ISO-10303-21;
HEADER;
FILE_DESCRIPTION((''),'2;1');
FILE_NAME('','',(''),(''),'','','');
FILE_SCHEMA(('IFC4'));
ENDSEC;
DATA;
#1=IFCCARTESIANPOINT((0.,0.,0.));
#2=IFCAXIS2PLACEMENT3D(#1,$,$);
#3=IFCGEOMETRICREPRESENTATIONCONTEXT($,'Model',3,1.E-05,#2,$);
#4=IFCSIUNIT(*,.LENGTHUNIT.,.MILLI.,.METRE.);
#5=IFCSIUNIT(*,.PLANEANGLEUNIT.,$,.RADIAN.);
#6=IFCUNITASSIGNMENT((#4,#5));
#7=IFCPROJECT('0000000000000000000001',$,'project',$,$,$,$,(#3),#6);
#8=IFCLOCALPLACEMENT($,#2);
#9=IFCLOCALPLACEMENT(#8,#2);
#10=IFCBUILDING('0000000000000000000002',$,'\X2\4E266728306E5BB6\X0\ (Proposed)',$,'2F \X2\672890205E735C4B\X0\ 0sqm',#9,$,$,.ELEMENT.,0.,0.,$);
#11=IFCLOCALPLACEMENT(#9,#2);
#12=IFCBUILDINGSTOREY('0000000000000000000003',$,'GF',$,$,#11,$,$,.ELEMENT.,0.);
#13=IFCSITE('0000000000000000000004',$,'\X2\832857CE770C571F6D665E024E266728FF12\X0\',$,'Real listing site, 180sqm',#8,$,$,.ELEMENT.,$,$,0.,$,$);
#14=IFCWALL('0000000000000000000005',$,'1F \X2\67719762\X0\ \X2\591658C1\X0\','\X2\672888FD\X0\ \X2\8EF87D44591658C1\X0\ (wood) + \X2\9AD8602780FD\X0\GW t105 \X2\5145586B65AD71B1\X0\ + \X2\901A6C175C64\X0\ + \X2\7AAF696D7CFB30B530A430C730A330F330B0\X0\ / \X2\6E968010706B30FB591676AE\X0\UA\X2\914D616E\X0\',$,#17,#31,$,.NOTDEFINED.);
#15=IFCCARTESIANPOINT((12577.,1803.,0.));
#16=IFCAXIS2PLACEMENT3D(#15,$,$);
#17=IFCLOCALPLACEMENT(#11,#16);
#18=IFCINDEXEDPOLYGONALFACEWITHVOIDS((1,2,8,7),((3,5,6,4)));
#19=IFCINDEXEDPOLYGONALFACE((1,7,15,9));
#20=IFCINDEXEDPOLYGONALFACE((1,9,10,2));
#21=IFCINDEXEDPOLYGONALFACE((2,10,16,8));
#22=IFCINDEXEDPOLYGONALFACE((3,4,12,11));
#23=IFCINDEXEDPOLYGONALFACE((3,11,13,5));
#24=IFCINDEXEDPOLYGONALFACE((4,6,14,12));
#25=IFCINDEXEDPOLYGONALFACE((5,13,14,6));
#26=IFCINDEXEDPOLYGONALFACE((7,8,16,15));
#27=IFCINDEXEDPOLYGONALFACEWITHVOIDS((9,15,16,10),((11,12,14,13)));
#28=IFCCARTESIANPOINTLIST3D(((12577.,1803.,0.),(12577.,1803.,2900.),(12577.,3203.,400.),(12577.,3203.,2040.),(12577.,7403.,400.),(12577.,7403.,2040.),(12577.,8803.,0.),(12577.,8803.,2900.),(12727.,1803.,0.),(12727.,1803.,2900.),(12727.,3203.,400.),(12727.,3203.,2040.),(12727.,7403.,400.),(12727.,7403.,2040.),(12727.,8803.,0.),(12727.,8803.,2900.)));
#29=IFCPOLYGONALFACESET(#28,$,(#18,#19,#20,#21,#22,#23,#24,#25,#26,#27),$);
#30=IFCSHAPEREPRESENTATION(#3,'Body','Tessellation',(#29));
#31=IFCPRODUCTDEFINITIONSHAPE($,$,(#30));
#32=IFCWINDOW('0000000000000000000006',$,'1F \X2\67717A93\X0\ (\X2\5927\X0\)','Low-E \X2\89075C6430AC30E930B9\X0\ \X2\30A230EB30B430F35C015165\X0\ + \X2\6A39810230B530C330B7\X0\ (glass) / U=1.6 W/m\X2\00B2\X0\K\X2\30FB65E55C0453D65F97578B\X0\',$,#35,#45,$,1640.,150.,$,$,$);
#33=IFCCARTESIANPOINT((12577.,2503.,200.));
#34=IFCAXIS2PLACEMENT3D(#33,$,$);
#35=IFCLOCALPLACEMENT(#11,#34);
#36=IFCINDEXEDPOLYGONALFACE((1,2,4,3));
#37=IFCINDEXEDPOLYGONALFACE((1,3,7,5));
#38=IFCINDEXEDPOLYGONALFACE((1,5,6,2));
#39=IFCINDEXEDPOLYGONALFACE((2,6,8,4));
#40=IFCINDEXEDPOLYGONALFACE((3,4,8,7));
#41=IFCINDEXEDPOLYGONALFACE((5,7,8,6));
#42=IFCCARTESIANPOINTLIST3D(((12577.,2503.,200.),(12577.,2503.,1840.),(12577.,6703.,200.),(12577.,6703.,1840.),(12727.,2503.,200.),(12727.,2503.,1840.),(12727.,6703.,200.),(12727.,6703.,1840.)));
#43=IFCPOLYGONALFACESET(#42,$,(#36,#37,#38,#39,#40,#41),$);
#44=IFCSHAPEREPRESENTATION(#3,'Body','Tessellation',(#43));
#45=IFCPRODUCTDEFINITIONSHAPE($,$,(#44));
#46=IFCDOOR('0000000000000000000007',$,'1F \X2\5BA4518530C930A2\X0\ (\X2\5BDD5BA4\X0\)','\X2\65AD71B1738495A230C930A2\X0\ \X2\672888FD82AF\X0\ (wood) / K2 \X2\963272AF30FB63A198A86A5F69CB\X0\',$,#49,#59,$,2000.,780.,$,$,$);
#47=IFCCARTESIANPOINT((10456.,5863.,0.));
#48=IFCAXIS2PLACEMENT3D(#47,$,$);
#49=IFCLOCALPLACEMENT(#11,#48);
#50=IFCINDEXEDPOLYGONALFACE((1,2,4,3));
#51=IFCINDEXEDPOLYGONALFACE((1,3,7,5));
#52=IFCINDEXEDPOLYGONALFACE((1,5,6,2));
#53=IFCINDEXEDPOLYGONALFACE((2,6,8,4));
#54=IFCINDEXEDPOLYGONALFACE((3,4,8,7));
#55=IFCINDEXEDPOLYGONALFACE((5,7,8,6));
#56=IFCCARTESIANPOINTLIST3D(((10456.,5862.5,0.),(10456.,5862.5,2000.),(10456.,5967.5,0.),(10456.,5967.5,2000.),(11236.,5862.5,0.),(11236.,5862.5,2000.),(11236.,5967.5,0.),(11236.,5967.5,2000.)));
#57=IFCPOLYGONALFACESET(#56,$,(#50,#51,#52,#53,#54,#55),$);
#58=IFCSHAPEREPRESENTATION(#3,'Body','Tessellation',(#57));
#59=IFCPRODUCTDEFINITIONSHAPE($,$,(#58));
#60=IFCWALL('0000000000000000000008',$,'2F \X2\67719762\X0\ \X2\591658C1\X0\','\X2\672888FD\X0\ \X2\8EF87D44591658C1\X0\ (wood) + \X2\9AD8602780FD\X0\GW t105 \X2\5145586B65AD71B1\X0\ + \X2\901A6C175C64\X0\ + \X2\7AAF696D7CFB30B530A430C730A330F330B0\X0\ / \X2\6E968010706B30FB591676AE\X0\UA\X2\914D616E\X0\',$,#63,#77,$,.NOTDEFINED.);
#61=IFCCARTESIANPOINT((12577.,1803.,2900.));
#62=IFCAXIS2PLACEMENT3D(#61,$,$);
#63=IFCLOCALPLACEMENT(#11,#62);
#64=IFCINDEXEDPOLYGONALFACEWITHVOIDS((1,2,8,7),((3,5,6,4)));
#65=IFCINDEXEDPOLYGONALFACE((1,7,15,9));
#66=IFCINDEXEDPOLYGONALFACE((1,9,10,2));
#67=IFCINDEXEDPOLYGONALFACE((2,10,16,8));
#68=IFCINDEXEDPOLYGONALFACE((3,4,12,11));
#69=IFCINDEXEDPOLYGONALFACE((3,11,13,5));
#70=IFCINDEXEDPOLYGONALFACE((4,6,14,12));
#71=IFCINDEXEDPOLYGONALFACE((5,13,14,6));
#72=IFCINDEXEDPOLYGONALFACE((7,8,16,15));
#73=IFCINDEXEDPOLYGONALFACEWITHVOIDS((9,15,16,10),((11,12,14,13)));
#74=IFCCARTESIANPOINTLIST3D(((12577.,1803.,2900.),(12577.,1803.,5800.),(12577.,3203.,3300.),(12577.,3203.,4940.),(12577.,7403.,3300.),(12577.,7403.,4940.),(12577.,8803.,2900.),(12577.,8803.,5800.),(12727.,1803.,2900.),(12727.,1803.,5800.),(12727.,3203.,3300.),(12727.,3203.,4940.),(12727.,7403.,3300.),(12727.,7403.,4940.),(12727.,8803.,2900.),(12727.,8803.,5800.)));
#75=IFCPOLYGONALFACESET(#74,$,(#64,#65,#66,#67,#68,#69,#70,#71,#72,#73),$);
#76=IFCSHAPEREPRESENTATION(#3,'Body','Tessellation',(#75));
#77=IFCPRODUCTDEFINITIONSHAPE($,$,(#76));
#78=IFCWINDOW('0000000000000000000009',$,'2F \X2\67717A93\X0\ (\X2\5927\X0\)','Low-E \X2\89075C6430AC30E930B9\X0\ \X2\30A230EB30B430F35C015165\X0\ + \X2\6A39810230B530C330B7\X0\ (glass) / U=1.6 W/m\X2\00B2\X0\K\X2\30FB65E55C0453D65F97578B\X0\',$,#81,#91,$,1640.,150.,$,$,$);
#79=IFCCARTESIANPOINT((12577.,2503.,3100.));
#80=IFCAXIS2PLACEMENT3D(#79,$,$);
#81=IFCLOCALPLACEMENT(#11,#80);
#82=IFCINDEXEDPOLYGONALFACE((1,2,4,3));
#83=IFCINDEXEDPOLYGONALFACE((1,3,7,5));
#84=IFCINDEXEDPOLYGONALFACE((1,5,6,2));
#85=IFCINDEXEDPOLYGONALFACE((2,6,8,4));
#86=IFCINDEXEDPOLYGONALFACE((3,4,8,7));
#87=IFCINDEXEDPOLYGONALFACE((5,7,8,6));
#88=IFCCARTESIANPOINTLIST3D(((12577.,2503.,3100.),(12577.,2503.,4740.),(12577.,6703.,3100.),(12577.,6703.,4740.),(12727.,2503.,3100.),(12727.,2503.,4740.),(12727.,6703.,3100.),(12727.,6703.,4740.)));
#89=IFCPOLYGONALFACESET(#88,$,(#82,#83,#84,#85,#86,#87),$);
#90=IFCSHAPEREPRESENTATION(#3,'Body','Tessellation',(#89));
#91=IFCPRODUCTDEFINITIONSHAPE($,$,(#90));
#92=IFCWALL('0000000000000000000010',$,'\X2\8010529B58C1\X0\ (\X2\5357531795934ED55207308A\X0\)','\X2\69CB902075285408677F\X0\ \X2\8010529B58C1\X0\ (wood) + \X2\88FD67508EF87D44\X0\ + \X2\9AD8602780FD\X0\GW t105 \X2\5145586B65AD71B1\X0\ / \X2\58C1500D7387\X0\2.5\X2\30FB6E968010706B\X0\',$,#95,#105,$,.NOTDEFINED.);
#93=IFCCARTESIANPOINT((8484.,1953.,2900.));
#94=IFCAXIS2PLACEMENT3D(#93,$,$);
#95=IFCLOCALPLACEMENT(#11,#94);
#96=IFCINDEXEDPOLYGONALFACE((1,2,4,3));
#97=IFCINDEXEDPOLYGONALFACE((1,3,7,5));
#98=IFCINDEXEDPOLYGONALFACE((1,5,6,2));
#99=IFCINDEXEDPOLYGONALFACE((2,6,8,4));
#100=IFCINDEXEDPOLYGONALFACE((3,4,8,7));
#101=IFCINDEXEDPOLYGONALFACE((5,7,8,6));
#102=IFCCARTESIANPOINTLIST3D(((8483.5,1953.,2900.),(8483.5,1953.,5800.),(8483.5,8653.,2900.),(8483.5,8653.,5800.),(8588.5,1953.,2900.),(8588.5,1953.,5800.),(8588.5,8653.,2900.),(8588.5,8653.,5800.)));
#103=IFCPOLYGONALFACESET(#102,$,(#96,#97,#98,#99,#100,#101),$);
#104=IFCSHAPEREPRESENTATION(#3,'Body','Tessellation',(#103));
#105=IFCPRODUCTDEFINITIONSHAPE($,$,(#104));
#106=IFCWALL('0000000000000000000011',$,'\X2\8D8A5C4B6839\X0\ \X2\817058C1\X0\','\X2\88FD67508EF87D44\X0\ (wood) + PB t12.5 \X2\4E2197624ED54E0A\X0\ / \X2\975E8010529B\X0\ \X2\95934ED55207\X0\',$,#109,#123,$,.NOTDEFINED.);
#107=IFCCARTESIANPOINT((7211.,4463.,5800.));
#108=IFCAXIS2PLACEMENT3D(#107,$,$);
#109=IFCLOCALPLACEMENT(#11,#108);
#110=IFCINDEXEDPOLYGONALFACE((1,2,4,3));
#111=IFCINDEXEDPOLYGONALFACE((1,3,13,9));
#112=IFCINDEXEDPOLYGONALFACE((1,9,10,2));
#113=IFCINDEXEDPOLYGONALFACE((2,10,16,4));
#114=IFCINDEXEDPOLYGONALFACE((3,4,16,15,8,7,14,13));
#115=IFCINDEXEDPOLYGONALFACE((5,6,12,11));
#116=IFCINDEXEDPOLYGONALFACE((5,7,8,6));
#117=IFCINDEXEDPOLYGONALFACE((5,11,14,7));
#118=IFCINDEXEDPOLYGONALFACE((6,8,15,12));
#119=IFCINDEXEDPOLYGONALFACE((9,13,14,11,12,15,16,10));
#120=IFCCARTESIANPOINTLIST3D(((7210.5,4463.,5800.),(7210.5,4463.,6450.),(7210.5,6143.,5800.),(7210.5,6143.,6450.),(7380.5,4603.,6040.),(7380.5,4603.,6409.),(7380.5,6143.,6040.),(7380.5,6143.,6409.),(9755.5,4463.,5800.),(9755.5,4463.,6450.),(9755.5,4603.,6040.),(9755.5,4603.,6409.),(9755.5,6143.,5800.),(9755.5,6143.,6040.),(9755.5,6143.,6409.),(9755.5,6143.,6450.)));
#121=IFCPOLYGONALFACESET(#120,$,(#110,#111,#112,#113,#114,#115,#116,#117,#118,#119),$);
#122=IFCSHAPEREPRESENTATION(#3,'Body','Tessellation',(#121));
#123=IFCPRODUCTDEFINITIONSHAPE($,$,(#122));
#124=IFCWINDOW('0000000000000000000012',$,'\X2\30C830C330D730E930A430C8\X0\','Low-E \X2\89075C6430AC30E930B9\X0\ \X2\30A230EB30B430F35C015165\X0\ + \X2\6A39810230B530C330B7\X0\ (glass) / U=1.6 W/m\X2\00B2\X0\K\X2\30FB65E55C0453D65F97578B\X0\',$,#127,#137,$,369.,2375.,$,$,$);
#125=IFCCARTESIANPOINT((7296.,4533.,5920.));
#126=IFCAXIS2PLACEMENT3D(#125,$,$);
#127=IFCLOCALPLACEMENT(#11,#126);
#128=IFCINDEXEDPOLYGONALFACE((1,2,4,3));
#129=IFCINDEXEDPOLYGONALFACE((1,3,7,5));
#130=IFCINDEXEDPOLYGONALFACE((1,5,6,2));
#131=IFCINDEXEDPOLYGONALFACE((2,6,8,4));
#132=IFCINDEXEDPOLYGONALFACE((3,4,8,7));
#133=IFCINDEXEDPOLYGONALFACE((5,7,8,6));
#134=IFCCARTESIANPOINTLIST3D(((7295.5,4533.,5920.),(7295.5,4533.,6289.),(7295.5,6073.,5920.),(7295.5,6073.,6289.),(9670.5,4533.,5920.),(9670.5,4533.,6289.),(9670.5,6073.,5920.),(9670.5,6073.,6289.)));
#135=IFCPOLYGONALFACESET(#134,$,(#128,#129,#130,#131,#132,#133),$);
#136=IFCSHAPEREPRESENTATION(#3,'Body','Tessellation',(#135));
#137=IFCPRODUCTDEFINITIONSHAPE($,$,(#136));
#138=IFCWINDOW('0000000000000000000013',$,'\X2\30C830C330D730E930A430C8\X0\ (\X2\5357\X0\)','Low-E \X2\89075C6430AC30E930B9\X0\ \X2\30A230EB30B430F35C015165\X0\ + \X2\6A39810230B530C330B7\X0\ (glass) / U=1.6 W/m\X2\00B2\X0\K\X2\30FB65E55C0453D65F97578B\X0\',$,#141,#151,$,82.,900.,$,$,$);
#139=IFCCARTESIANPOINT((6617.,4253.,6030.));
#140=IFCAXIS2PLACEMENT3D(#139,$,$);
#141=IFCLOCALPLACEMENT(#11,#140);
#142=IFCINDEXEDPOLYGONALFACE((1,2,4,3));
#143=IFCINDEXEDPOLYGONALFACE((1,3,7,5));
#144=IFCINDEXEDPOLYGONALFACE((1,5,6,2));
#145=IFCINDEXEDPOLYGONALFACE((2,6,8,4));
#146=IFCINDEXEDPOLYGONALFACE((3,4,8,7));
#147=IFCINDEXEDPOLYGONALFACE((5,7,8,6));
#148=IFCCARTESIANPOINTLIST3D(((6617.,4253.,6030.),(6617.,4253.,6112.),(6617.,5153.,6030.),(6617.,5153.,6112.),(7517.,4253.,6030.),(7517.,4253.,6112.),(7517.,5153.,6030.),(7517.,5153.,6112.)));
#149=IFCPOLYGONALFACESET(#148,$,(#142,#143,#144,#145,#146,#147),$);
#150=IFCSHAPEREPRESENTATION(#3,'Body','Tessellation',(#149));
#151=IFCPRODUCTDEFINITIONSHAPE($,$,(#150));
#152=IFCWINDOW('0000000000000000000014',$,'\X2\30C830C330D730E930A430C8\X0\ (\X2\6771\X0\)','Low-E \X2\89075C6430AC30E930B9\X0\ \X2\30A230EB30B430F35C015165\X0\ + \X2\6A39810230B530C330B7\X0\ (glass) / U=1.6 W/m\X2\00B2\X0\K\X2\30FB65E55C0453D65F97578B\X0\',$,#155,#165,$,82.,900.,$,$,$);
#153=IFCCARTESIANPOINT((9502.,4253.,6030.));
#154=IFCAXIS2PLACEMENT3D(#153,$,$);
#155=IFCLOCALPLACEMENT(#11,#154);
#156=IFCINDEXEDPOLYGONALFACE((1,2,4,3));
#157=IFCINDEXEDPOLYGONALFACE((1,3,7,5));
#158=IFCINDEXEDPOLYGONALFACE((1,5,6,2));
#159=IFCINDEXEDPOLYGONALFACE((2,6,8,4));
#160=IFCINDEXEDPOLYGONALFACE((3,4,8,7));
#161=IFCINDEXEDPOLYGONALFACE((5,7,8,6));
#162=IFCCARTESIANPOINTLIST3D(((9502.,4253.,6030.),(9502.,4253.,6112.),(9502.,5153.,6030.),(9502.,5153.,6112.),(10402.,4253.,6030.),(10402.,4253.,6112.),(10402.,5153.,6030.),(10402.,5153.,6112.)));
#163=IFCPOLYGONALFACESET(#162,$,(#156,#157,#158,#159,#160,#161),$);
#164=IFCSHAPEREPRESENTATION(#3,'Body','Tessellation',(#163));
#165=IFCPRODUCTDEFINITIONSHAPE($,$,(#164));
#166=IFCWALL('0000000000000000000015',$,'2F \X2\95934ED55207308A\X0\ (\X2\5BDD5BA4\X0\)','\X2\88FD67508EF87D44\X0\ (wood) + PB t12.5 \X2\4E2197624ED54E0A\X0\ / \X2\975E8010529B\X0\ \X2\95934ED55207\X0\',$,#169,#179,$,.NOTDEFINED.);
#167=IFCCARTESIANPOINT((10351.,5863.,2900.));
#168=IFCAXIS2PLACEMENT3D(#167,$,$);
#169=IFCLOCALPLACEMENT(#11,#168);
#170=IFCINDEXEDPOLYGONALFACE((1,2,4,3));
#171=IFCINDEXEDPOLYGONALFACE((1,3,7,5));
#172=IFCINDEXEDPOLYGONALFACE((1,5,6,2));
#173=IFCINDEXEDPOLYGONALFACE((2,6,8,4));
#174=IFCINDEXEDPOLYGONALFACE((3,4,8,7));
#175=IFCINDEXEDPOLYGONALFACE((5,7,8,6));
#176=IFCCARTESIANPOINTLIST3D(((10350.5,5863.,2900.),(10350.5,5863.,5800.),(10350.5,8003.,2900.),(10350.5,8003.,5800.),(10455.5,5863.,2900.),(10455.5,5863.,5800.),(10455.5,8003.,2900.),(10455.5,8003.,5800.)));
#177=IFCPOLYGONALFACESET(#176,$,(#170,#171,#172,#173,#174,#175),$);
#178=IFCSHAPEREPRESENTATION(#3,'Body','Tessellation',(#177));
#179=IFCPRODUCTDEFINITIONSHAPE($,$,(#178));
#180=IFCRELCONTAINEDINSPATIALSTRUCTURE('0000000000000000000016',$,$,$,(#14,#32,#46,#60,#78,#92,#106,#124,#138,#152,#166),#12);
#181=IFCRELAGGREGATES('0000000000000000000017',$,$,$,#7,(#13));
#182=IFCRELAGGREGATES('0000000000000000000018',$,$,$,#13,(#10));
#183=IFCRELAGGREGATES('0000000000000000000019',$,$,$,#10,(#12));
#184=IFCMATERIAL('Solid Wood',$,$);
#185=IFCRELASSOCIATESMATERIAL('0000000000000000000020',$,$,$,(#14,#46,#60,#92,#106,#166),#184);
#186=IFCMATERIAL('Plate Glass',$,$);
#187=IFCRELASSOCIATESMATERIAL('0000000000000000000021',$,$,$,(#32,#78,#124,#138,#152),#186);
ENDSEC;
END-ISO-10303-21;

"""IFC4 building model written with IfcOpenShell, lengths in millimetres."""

from ifc_helpers import new_model, si_unit, frame, frame_2d, origin, place, context, project, spatial, rectangle, extrude, material, element, fill, save


model = new_model("IFC4")

# Units and contexts
model_context = context("Model", 3, precision=1e-05, world=origin())
ifc_project = project(units=[si_unit("LENGTHUNIT", "METRE", prefix="MILLI"), si_unit("PLANEANGLEUNIT", "RADIAN")], contexts=[model_context])

# Site, building, storey
site_placement = place(None, origin())
site = spatial("IfcSite", under=ifc_project, at=site_placement, Name="茨城県土浦市並木２", ObjectType="Real listing site, 180sqm", CompositionType="ELEMENT", RefElevation=0.0)
building_placement = place(site_placement, origin())
building = spatial("IfcBuilding", under=site, at=building_placement, Name="並木の家 (Proposed)", ObjectType="2F 木造平屋 0sqm", CompositionType="ELEMENT", ElevationOfRefHeight=0.0, ElevationOfTerrain=0.0)
storey_placement = place(building_placement, origin())
storey = spatial("IfcBuildingStorey", under=building, at=storey_placement, Name="GF", CompositionType="ELEMENT", Elevation=0.0)

# Wall, opening, window
ifc_material_1 = material(Name="Solid Wood")
wall_1_placement = place(storey_placement, frame((12577.0, 1803.0, 0.0)))
wall_1 = element("IfcWall", 1, at=wall_1_placement, inside=storey, material=ifc_material_1, Name="1F 東面 外壁", Description="木製 軸組外壁 (wood) + 高性能GW t105 充填断熱 + 通気層 + 窯業系サイディング / 準耐火・外皮UA配慮", PredefinedType="NOTDEFINED", context=model_context, shape_type="SweptSolid", body=[
    extrude(rectangle(XDim=150.0, YDim=7000.0, at=frame_2d((75.0, 3500.0))), frame((12577.0, 1803.0, 0.0)), (0.0, 0.0, 1.0), 2900.0),
])
opening_1_placement = place(storey_placement, frame((12577.0, 2503.0, 200.0)))
opening_1 = element("IfcOpeningElement", 2, at=opening_1_placement, cuts=wall_1, PredefinedType="NOTDEFINED", context=model_context, shape_type="SweptSolid", body=[
    extrude(rectangle(XDim=150.0, YDim=4200.0, at=frame_2d((75.0, 2100.0))), frame((12577.0, 2503.0, 200.0)), (0.0, 0.0, 1.0), 1640.0),
])
ifc_material_2 = material(Name="Plate Glass")
window_1_placement = place(storey_placement, frame((12577.0, 2503.0, 200.0)))
window_1 = element("IfcWindow", 3, at=window_1_placement, inside=storey, material=ifc_material_2, Name="1F 東窓 (大)", Description="Low-E 複層ガラス アルゴン封入 + 樹脂サッシ (glass) / U=1.6 W/m²K・日射取得型", OverallHeight=1640.0, OverallWidth=150.0, context=model_context, shape_type="SweptSolid", body=[
    extrude(rectangle(XDim=150.0, YDim=4200.0, at=frame_2d((75.0, 2100.0))), frame((12577.0, 2503.0, 200.0)), (0.0, 0.0, 1.0), 1640.0),
])
fill(opening_1, window_1)

# Door
door_1_placement = place(storey_placement, frame((10456.0, 5863.0, 0.0)))
element("IfcDoor", 4, at=door_1_placement, inside=storey, material=ifc_material_1, Name="1F 室内ドア (寝室)", Description="断熱玄関ドア 木製芯 (wood) / K2 防犯・採風機構", OverallHeight=2000.0, OverallWidth=780.0, context=model_context, shape_type="SweptSolid", body=[
    extrude(rectangle(XDim=780.0, YDim=105.0, at=frame_2d((390.0, 52.0))), frame((10456.0, 5863.0, 0.0)), (0.0, 0.0, 1.0), 2000.0),
])

# Wall, opening, window
wall_2_placement = place(storey_placement, frame((12577.0, 1803.0, 2900.0)))
wall_2 = element("IfcWall", 5, at=wall_2_placement, inside=storey, material=ifc_material_1, Name="2F 東面 外壁", Description="木製 軸組外壁 (wood) + 高性能GW t105 充填断熱 + 通気層 + 窯業系サイディング / 準耐火・外皮UA配慮", PredefinedType="NOTDEFINED", context=model_context, shape_type="SweptSolid", body=[
    extrude(rectangle(XDim=150.0, YDim=7000.0, at=frame_2d((75.0, 3500.0))), frame((12577.0, 1803.0, 2900.0)), (0.0, 0.0, 1.0), 2900.0),
])
opening_2_placement = place(storey_placement, frame((12577.0, 2503.0, 3100.0)))
opening_2 = element("IfcOpeningElement", 6, at=opening_2_placement, cuts=wall_2, PredefinedType="NOTDEFINED", context=model_context, shape_type="SweptSolid", body=[
    extrude(rectangle(XDim=150.0, YDim=4200.0, at=frame_2d((75.0, 2100.0))), frame((12577.0, 2503.0, 3100.0)), (0.0, 0.0, 1.0), 1640.0),
])
window_2_placement = place(storey_placement, frame((12577.0, 2503.0, 3100.0)))
window_2 = element("IfcWindow", 7, at=window_2_placement, inside=storey, material=ifc_material_2, Name="2F 東窓 (大)", Description="Low-E 複層ガラス アルゴン封入 + 樹脂サッシ (glass) / U=1.6 W/m²K・日射取得型", OverallHeight=1640.0, OverallWidth=150.0, context=model_context, shape_type="SweptSolid", body=[
    extrude(rectangle(XDim=150.0, YDim=4200.0, at=frame_2d((75.0, 2100.0))), frame((12577.0, 2503.0, 3100.0)), (0.0, 0.0, 1.0), 1640.0),
])
fill(opening_2, window_2)

# Wall
wall_3_placement = place(storey_placement, frame((8484.0, 1953.0, 2900.0)))
element("IfcWall", 8, at=wall_3_placement, inside=storey, material=ifc_material_1, Name="耐力壁 (南北間仕切り)", Description="構造用合板 耐力壁 (wood) + 製材軸組 + 高性能GW t105 充填断熱 / 壁倍率2.5・準耐火", PredefinedType="NOTDEFINED", context=model_context, shape_type="SweptSolid", body=[
    extrude(rectangle(XDim=105.0, YDim=6700.0, at=frame_2d((52.0, 3350.0))), frame((8484.0, 1953.0, 2900.0)), (0.0, 0.0, 1.0), 2900.0),
])

# Wall, openings, windows
wall_4_placement = place(storey_placement, frame((7211.0, 4463.0, 5800.0)))
wall_4 = element("IfcWall", 9, at=wall_4_placement, inside=storey, material=ifc_material_1, Name="越屋根 腰壁", Description="製材軸組 (wood) + PB t12.5 両面仕上 / 非耐力 間仕切", PredefinedType="NOTDEFINED", context=model_context, shape_type="SweptSolid", body=[
    extrude(rectangle(XDim=2545.0, YDim=1680.0, at=frame_2d((1272.0, 840.0))), frame((7211.0, 4463.0, 5800.0)), (0.0, 0.0, 1.0), 650.0),
])
opening_3_placement = place(storey_placement, frame((7296.0, 4533.0, 5920.0)))
opening_3 = element("IfcOpeningElement", 10, at=opening_3_placement, cuts=wall_4, PredefinedType="NOTDEFINED", context=model_context, shape_type="SweptSolid", body=[
    extrude(rectangle(XDim=2375.0, YDim=1540.0, at=frame_2d((1187.0, 770.0))), frame((7296.0, 4533.0, 5920.0)), (0.0, 0.0, 1.0), 369.0),
])
opening_4_placement = place(storey_placement, frame((6617.0, 4253.0, 6030.0)))
opening_4 = element("IfcOpeningElement", 11, at=opening_4_placement, cuts=wall_4, PredefinedType="NOTDEFINED", context=model_context, shape_type="SweptSolid", body=[
    extrude(rectangle(XDim=900.0, YDim=900.0, at=frame_2d((450.0, 450.0))), frame((6617.0, 4253.0, 6030.0)), (0.0, 0.0, 1.0), 82.0),
])
opening_5_placement = place(storey_placement, frame((9502.0, 4253.0, 6030.0)))
opening_5 = element("IfcOpeningElement", 12, at=opening_5_placement, cuts=wall_4, PredefinedType="NOTDEFINED", context=model_context, shape_type="SweptSolid", body=[
    extrude(rectangle(XDim=900.0, YDim=900.0, at=frame_2d((450.0, 450.0))), frame((9502.0, 4253.0, 6030.0)), (0.0, 0.0, 1.0), 82.0),
])
window_3_placement = place(storey_placement, frame((7296.0, 4533.0, 5920.0)))
window_3 = element("IfcWindow", 13, at=window_3_placement, inside=storey, material=ifc_material_2, Name="トップライト", Description="Low-E 複層ガラス アルゴン封入 + 樹脂サッシ (glass) / U=1.6 W/m²K・日射取得型", OverallHeight=369.0, OverallWidth=2375.0, context=model_context, shape_type="SweptSolid", body=[
    extrude(rectangle(XDim=2375.0, YDim=1540.0, at=frame_2d((1187.0, 770.0))), frame((7296.0, 4533.0, 5920.0)), (0.0, 0.0, 1.0), 369.0),
])
fill(opening_3, window_3)
window_4_placement = place(storey_placement, frame((6617.0, 4253.0, 6030.0)))
window_4 = element("IfcWindow", 14, at=window_4_placement, inside=storey, material=ifc_material_2, Name="トップライト (南)", Description="Low-E 複層ガラス アルゴン封入 + 樹脂サッシ (glass) / U=1.6 W/m²K・日射取得型", OverallHeight=82.0, OverallWidth=900.0, context=model_context, shape_type="SweptSolid", body=[
    extrude(rectangle(XDim=900.0, YDim=900.0, at=frame_2d((450.0, 450.0))), frame((6617.0, 4253.0, 6030.0)), (0.0, 0.0, 1.0), 82.0),
])
fill(opening_4, window_4)
window_5_placement = place(storey_placement, frame((9502.0, 4253.0, 6030.0)))
window_5 = element("IfcWindow", 15, at=window_5_placement, inside=storey, material=ifc_material_2, Name="トップライト (東)", Description="Low-E 複層ガラス アルゴン封入 + 樹脂サッシ (glass) / U=1.6 W/m²K・日射取得型", OverallHeight=82.0, OverallWidth=900.0, context=model_context, shape_type="SweptSolid", body=[
    extrude(rectangle(XDim=900.0, YDim=900.0, at=frame_2d((450.0, 450.0))), frame((9502.0, 4253.0, 6030.0)), (0.0, 0.0, 1.0), 82.0),
])
fill(opening_5, window_5)

# Wall
wall_5_placement = place(storey_placement, frame((10351.0, 5863.0, 2900.0)))
element("IfcWall", 16, at=wall_5_placement, inside=storey, material=ifc_material_1, Name="2F 間仕切り (寝室)", Description="製材軸組 (wood) + PB t12.5 両面仕上 / 非耐力 間仕切", PredefinedType="NOTDEFINED", context=model_context, shape_type="SweptSolid", body=[
    extrude(rectangle(XDim=105.0, YDim=2140.0, at=frame_2d((52.0, 1070.0))), frame((10351.0, 5863.0, 2900.0)), (0.0, 0.0, 1.0), 2900.0),
])

save(model, "model.ifc")
